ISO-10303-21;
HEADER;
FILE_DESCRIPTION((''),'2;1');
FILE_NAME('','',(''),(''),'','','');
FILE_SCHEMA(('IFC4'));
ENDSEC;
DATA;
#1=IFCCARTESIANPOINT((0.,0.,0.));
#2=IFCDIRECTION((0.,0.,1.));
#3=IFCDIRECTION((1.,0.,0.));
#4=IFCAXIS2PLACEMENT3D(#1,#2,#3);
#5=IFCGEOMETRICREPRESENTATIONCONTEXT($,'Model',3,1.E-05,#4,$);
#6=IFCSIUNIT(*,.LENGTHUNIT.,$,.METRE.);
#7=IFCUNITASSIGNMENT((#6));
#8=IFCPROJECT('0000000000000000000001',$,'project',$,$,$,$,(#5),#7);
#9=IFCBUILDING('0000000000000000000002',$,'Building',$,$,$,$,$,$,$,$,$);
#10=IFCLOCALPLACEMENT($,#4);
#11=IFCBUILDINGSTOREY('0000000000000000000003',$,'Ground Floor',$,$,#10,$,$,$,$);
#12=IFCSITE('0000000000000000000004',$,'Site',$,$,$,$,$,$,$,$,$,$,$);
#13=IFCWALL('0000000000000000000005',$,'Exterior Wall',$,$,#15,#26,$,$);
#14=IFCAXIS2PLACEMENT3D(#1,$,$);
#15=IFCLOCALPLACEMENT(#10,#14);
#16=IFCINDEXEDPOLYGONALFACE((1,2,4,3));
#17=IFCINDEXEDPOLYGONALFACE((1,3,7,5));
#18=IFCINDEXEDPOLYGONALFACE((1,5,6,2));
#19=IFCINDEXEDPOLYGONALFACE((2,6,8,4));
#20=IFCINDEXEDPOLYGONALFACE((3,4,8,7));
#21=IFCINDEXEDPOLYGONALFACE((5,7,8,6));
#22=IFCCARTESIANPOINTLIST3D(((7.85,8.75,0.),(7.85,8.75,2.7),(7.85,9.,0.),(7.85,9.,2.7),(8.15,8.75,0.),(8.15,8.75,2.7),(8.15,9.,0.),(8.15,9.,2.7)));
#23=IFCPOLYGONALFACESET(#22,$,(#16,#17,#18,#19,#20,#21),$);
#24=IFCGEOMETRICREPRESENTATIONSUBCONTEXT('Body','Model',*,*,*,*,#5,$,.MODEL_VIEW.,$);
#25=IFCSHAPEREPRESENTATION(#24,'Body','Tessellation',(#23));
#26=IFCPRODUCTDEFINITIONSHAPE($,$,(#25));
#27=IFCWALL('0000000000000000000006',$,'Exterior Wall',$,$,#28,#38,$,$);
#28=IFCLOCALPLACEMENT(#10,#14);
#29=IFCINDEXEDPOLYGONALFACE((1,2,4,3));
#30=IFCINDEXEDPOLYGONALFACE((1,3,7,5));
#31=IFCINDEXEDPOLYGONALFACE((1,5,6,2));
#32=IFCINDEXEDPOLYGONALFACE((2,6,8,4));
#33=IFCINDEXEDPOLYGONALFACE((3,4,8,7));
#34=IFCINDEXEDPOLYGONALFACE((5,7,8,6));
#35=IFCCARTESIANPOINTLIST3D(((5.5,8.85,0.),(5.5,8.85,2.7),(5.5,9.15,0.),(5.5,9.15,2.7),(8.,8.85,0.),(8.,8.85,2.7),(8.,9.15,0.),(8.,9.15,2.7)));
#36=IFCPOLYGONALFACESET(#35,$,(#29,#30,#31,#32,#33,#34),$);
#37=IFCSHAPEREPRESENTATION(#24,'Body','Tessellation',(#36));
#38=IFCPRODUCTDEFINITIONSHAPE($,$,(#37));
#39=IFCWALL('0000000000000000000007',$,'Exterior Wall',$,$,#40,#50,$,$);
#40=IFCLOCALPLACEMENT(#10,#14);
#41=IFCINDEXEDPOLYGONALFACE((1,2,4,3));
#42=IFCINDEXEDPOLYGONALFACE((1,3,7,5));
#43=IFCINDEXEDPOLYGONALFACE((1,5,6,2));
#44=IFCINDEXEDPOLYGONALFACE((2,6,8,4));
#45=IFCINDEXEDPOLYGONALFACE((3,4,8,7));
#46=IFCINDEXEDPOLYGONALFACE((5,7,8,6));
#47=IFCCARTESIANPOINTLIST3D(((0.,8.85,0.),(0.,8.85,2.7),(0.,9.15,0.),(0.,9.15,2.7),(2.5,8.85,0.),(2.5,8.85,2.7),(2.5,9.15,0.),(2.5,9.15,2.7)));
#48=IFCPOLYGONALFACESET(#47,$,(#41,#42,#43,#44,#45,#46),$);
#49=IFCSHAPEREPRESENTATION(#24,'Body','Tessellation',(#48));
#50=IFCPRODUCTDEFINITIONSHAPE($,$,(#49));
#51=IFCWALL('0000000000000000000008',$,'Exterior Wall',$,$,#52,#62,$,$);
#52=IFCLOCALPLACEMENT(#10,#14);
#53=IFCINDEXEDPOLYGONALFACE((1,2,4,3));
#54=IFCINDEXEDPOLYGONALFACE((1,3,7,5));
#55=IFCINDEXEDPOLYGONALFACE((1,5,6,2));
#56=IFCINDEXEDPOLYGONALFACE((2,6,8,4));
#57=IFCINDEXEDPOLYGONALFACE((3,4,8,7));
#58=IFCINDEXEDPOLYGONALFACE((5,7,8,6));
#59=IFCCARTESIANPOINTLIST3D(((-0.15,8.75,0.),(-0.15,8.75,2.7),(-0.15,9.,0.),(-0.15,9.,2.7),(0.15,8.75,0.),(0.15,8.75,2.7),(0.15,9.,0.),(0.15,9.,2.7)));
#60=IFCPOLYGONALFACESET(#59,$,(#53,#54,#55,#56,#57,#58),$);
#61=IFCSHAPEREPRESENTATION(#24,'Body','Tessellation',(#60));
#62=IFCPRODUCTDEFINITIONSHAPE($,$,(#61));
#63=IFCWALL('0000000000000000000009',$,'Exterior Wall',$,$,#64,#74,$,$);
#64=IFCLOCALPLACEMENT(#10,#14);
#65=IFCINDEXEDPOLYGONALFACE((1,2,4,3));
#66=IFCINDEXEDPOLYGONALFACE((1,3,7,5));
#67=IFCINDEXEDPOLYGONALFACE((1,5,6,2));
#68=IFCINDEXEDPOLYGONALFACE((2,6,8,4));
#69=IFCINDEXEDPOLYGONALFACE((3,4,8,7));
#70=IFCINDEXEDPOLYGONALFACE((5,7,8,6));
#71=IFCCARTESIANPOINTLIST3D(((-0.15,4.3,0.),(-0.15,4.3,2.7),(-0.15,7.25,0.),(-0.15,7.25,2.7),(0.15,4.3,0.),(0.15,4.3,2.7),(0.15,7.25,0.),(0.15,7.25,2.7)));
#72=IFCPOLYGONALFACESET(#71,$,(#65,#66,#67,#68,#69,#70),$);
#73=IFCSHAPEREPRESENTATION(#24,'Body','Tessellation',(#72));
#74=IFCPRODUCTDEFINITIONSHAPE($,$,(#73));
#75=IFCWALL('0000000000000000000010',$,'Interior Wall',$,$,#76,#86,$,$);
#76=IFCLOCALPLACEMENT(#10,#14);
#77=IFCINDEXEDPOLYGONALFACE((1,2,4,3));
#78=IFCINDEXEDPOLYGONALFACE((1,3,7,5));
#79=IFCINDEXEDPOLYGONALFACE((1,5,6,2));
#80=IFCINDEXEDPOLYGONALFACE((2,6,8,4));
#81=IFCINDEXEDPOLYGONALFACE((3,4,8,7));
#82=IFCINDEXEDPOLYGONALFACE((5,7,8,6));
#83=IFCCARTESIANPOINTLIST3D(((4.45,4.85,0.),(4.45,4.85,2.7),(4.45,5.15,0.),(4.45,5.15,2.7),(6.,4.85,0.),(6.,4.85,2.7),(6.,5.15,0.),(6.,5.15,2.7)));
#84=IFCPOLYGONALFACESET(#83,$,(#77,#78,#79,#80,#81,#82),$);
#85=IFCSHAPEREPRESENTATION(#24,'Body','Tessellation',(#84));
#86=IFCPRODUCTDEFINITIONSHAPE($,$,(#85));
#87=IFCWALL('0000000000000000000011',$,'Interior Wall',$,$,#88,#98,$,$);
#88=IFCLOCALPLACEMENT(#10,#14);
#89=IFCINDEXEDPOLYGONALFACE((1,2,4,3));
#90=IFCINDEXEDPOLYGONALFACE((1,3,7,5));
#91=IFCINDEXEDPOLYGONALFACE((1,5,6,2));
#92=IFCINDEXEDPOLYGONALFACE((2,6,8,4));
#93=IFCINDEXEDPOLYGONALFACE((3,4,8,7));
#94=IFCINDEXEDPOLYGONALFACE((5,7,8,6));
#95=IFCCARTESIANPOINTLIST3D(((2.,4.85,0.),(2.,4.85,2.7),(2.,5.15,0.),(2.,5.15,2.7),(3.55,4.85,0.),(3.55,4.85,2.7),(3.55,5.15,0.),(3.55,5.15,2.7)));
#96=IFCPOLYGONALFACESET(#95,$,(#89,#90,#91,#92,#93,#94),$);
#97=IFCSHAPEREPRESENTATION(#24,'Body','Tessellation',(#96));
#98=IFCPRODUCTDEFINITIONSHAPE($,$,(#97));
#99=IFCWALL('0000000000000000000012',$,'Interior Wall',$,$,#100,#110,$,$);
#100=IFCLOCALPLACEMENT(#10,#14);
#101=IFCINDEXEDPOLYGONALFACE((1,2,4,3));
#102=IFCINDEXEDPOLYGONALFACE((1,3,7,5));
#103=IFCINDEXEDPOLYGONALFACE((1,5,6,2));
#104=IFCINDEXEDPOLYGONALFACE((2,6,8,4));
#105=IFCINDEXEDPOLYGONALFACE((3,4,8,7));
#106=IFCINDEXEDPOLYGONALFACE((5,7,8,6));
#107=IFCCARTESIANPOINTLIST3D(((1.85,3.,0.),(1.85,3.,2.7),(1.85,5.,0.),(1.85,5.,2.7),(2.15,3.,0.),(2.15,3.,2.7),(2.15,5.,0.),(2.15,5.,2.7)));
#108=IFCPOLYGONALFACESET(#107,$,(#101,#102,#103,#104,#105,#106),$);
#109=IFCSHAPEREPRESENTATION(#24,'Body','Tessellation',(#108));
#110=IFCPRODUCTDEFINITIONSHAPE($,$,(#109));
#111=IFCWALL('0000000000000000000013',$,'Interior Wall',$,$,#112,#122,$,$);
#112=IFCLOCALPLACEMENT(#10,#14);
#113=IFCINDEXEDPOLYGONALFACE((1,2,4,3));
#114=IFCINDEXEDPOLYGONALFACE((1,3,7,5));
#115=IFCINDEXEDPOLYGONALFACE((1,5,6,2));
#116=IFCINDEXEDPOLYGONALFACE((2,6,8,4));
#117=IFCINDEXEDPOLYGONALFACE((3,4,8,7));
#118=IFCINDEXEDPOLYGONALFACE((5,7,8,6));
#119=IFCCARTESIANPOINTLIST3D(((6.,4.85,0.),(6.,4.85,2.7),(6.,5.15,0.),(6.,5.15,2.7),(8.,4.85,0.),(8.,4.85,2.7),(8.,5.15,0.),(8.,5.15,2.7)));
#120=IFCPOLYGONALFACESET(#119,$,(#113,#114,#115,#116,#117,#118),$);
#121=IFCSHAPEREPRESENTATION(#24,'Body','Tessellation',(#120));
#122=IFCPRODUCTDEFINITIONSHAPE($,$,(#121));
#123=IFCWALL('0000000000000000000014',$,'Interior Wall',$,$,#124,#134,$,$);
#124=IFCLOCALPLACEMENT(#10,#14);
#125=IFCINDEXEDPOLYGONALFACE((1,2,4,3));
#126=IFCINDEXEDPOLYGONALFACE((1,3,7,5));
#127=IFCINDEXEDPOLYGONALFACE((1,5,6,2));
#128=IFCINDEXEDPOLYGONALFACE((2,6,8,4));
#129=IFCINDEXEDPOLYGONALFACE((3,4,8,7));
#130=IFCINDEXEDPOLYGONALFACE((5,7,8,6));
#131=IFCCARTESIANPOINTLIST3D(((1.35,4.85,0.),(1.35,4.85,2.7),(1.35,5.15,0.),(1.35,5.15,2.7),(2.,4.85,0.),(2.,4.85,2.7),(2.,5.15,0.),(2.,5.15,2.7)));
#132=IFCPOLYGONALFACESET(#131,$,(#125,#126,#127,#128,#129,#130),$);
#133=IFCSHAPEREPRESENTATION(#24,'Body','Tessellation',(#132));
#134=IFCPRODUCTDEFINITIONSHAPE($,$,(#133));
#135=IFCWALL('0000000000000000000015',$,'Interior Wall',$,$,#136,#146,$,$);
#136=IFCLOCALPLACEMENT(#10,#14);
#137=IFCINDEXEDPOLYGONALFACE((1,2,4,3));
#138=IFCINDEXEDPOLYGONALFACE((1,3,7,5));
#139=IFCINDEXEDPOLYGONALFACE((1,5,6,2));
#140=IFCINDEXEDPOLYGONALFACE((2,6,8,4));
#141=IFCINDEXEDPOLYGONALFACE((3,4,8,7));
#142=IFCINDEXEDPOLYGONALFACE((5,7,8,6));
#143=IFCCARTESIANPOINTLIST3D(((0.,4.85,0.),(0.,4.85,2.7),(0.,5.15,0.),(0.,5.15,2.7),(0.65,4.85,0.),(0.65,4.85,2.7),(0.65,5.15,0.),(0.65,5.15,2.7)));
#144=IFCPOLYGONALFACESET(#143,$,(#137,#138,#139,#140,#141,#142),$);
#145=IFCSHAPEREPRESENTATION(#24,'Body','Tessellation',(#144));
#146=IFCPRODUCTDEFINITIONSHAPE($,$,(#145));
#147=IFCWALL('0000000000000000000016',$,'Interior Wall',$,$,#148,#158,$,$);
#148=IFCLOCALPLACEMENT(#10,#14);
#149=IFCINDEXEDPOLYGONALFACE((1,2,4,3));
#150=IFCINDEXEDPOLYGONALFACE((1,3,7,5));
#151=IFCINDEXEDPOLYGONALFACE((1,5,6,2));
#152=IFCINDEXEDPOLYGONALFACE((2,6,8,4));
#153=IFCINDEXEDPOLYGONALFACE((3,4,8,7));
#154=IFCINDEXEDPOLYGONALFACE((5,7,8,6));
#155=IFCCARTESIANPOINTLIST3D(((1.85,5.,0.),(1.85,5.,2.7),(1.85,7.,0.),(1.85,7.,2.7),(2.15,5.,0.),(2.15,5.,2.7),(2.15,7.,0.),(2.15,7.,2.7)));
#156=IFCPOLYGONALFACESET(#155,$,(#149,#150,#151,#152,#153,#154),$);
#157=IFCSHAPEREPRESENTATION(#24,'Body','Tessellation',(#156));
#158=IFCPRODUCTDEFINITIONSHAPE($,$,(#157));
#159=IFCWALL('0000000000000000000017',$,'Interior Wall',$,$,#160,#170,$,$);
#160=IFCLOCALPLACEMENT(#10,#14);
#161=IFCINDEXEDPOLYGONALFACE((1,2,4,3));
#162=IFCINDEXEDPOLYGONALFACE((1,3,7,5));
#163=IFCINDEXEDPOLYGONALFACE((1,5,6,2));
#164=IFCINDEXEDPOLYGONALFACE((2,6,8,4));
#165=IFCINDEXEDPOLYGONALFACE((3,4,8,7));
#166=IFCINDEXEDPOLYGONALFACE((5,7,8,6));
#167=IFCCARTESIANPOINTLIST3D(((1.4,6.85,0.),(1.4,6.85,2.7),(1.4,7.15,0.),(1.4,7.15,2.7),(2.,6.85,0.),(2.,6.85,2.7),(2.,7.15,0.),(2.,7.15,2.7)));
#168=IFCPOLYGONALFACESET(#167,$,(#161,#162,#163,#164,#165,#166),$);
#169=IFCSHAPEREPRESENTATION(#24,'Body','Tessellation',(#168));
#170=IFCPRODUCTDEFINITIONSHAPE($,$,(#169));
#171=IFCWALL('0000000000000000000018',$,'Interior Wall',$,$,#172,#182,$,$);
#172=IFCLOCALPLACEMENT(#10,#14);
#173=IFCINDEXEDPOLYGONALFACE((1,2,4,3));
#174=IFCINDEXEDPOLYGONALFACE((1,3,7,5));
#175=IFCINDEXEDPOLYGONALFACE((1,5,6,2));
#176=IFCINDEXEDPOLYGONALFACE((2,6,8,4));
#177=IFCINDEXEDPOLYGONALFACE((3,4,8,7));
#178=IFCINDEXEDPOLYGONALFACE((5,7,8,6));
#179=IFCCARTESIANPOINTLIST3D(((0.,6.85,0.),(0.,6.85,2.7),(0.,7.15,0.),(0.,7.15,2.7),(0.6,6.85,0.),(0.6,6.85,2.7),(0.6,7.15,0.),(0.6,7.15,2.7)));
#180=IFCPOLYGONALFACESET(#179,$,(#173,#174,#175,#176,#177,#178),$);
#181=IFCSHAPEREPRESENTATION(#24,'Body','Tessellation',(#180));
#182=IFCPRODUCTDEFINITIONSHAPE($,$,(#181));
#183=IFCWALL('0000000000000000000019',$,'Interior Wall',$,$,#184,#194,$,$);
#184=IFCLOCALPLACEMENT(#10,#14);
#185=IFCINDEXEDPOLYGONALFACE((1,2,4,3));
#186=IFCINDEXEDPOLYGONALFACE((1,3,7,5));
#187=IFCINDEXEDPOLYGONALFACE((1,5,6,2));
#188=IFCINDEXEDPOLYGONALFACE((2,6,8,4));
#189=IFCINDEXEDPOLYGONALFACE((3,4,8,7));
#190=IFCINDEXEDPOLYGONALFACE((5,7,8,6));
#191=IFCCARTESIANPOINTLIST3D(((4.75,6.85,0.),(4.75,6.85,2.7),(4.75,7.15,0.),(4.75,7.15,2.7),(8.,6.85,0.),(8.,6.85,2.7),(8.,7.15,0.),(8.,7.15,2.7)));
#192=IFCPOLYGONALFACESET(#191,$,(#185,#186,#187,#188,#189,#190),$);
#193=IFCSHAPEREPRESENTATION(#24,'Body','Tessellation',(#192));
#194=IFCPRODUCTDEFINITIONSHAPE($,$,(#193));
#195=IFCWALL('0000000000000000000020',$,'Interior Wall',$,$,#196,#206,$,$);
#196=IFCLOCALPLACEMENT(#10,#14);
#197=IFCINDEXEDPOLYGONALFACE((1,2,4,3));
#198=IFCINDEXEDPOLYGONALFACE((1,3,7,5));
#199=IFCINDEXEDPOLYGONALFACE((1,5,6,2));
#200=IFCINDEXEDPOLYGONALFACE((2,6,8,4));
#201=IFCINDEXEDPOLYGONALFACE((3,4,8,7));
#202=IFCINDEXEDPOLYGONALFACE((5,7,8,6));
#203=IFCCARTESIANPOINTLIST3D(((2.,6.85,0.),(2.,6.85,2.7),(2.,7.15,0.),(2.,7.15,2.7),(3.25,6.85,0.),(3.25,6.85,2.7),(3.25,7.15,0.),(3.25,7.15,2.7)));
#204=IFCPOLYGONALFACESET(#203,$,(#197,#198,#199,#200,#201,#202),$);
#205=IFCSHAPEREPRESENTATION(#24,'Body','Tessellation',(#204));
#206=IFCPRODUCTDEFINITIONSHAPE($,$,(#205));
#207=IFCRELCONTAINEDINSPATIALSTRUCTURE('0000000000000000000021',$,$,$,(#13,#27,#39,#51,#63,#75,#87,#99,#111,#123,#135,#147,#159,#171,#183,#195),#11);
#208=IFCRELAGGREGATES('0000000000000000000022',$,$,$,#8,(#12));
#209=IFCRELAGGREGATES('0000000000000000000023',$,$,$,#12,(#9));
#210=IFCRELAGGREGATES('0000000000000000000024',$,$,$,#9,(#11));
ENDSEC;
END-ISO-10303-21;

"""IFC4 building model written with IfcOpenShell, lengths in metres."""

from ifc_helpers import new_model, si_unit, frame, origin_with_axes, place, context, subcontext, project, spatial, indexed_curve, outline, extrude, element, save


model = new_model("IFC4")

# Units and contexts
model_context = context("Model", 3, precision=1e-05, world=origin_with_axes())
body_context = subcontext(model_context, "Body", "Model", "MODEL_VIEW")
ifc_project = project(units=[si_unit("LENGTHUNIT", "METRE")], contexts=[model_context])

# Site, building, storey
site = spatial("IfcSite", under=ifc_project, Name="Site")
building = spatial("IfcBuilding", under=site, Name="Building")
storey_placement = place(None, origin_with_axes())
storey = spatial("IfcBuildingStorey", under=building, at=storey_placement, Name="Ground Floor")

# Walls
wall_1_placement = place(storey_placement, frame((8.0, 8.75, 0.0), z_axis=(0.0, 0.0, 1.0), x_axis=(0.0, 1.0, 0.0)))
element("IfcWall", 1, at=wall_1_placement, inside=storey, Name="Exterior Wall", context=body_context, shape_type="SweptSolid", body=[
    extrude(outline(indexed_curve([(0.0, 0.0), (0.0, 0.3), (0.25, 0.3), (0.25, 0.0), (0.0, 0.0)], self_intersect=False)), frame((0.0, -0.15, 0.0), z_axis=(0.0, 0.0, 1.0), x_axis=(1.0, 0.0, 0.0)), (0.0, 0.0, 1.0), 2.7),
])
for number, where, z_axis, x_axis, name in (
    (2, (8.0, 9.0, 0.0), (0.0, 0.0, 1.0), (-1.0, 0.0, 0.0), "Exterior Wall"),
    (3, (2.5, 9.0, 0.0), (0.0, 0.0, 1.0), (-1.0, 0.0, 0.0), "Exterior Wall"),
):
    element("IfcWall", number, at=place(storey_placement, frame(where, z_axis=z_axis, x_axis=x_axis)), inside=storey, Name=name, context=body_context, shape_type="SweptSolid", body=[
        extrude(outline(indexed_curve([(0.0, 0.0), (0.0, 0.3), (2.5, 0.3), (2.5, 0.0), (0.0, 0.0)], self_intersect=False)), frame((0.0, -0.15, 0.0), z_axis=(0.0, 0.0, 1.0), x_axis=(1.0, 0.0, 0.0)), (0.0, 0.0, 1.0), 2.7),
    ])
wall_2_placement = place(storey_placement, frame((0.0, 9.0, 0.0), z_axis=(0.0, 0.0, 1.0), x_axis=(0.0, -1.0, 0.0)))
element("IfcWall", 4, at=wall_2_placement, inside=storey, Name="Exterior Wall", context=body_context, shape_type="SweptSolid", body=[
    extrude(outline(indexed_curve([(0.0, 0.0), (0.0, 0.3), (0.25, 0.3), (0.25, 0.0), (0.0, 0.0)], self_intersect=False)), frame((0.0, -0.15, 0.0), z_axis=(0.0, 0.0, 1.0), x_axis=(1.0, 0.0, 0.0)), (0.0, 0.0, 1.0), 2.7),
])
wall_3_placement = place(storey_placement, frame((0.0, 7.25, 0.0), z_axis=(0.0, 0.0, 1.0), x_axis=(0.0, -1.0, 0.0)))
element("IfcWall", 5, at=wall_3_placement, inside=storey, Name="Exterior Wall", context=body_context, shape_type="SweptSolid", body=[
    extrude(outline(indexed_curve([(0.0, 0.0), (0.0, 0.3), (2.95, 0.3), (2.95, 0.0), (0.0, 0.0)], self_intersect=False)), frame((0.0, -0.15, 0.0), z_axis=(0.0, 0.0, 1.0), x_axis=(1.0, 0.0, 0.0)), (0.0, 0.0, 1.0), 2.7),
])
for number, where, z_axis, x_axis, name in (
    (6, (6.0, 5.0, 0.0), (0.0, 0.0, 1.0), (-1.0, 0.0, 0.0), "Interior Wall"),
    (7, (3.55, 5.0, 0.0), (0.0, 0.0, 1.0), (-1.0, 0.0, 0.0), "Interior Wall"),
):
    element("IfcWall", number, at=place(storey_placement, frame(where, z_axis=z_axis, x_axis=x_axis)), inside=storey, Name=name, context=body_context, shape_type="SweptSolid", body=[
        extrude(outline(indexed_curve([(0.0, 0.0), (0.0, 0.3), (1.55, 0.3), (1.55, 0.0), (0.0, 0.0)], self_intersect=False)), frame((0.0, -0.15, 0.0), z_axis=(0.0, 0.0, 1.0), x_axis=(1.0, 0.0, 0.0)), (0.0, 0.0, 1.0), 2.7),
    ])
for number, where, z_axis, x_axis, name in (
    (8, (2.0, 5.0, 0.0), (0.0, 0.0, 1.0), (0.0, -1.0, 0.0), "Interior Wall"),
    (9, (8.0, 5.0, 0.0), (0.0, 0.0, 1.0), (-1.0, 0.0, 0.0), "Interior Wall"),
):
    element("IfcWall", number, at=place(storey_placement, frame(where, z_axis=z_axis, x_axis=x_axis)), inside=storey, Name=name, context=body_context, shape_type="SweptSolid", body=[
        extrude(outline(indexed_curve([(0.0, 0.0), (0.0, 0.3), (2.0, 0.3), (2.0, 0.0), (0.0, 0.0)], self_intersect=False)), frame((0.0, -0.15, 0.0), z_axis=(0.0, 0.0, 1.0), x_axis=(1.0, 0.0, 0.0)), (0.0, 0.0, 1.0), 2.7),
    ])
for number, where, z_axis, x_axis, name in (
    (10, (2.0, 5.0, 0.0), (0.0, 0.0, 1.0), (-1.0, 0.0, 0.0), "Interior Wall"),
    (11, (0.65, 5.0, 0.0), (0.0, 0.0, 1.0), (-1.0, 0.0, 0.0), "Interior Wall"),
):
    element("IfcWall", number, at=place(storey_placement, frame(where, z_axis=z_axis, x_axis=x_axis)), inside=storey, Name=name, context=body_context, shape_type="SweptSolid", body=[
        extrude(outline(indexed_curve([(0.0, 0.0), (0.0, 0.3), (0.65, 0.3), (0.65, 0.0), (0.0, 0.0)], self_intersect=False)), frame((0.0, -0.15, 0.0), z_axis=(0.0, 0.0, 1.0), x_axis=(1.0, 0.0, 0.0)), (0.0, 0.0, 1.0), 2.7),
    ])
wall_4_placement = place(storey_placement, frame((2.0, 5.0, 0.0), z_axis=(0.0, 0.0, 1.0), x_axis=(0.0, 1.0, 0.0)))
element("IfcWall", 12, at=wall_4_placement, inside=storey, Name="Interior Wall", context=body_context, shape_type="SweptSolid", body=[
    extrude(outline(indexed_curve([(0.0, 0.0), (0.0, 0.3), (2.0, 0.3), (2.0, 0.0), (0.0, 0.0)], self_intersect=False)), frame((0.0, -0.15, 0.0), z_axis=(0.0, 0.0, 1.0), x_axis=(1.0, 0.0, 0.0)), (0.0, 0.0, 1.0), 2.7),
])
for number, where, z_axis, x_axis, name in (
    (13, (2.0, 7.0, 0.0), (0.0, 0.0, 1.0), (-1.0, 0.0, 0.0), "Interior Wall"),
    (14, (0.6, 7.0, 0.0), (0.0, 0.0, 1.0), (-1.0, 0.0, 0.0), "Interior Wall"),
):
    element("IfcWall", number, at=place(storey_placement, frame(where, z_axis=z_axis, x_axis=x_axis)), inside=storey, Name=name, context=body_context, shape_type="SweptSolid", body=[
        extrude(outline(indexed_curve([(0.0, 0.0), (0.0, 0.3), (0.6, 0.3), (0.6, 0.0), (0.0, 0.0)], self_intersect=False)), frame((0.0, -0.15, 0.0), z_axis=(0.0, 0.0, 1.0), x_axis=(1.0, 0.0, 0.0)), (0.0, 0.0, 1.0), 2.7),
    ])
wall_5_placement = place(storey_placement, frame((8.0, 7.0, 0.0), z_axis=(0.0, 0.0, 1.0), x_axis=(-1.0, 0.0, 0.0)))
element("IfcWall", 15, at=wall_5_placement, inside=storey, Name="Interior Wall", context=body_context, shape_type="SweptSolid", body=[
    extrude(outline(indexed_curve([(0.0, 0.0), (0.0, 0.3), (3.25, 0.3), (3.25, 0.0), (0.0, 0.0)], self_intersect=False)), frame((0.0, -0.15, 0.0), z_axis=(0.0, 0.0, 1.0), x_axis=(1.0, 0.0, 0.0)), (0.0, 0.0, 1.0), 2.7),
])
wall_6_placement = place(storey_placement, frame((3.25, 7.0, 0.0), z_axis=(0.0, 0.0, 1.0), x_axis=(-1.0, 0.0, 0.0)))
element("IfcWall", 16, at=wall_6_placement, inside=storey, Name="Interior Wall", context=body_context, shape_type="SweptSolid", body=[
    extrude(outline(indexed_curve([(0.0, 0.0), (0.0, 0.3), (1.25, 0.3), (1.25, 0.0), (0.0, 0.0)], self_intersect=False)), frame((0.0, -0.15, 0.0), z_axis=(0.0, 0.0, 1.0), x_axis=(1.0, 0.0, 0.0)), (0.0, 0.0, 1.0), 2.7),
])

save(model, "model.ifc")
